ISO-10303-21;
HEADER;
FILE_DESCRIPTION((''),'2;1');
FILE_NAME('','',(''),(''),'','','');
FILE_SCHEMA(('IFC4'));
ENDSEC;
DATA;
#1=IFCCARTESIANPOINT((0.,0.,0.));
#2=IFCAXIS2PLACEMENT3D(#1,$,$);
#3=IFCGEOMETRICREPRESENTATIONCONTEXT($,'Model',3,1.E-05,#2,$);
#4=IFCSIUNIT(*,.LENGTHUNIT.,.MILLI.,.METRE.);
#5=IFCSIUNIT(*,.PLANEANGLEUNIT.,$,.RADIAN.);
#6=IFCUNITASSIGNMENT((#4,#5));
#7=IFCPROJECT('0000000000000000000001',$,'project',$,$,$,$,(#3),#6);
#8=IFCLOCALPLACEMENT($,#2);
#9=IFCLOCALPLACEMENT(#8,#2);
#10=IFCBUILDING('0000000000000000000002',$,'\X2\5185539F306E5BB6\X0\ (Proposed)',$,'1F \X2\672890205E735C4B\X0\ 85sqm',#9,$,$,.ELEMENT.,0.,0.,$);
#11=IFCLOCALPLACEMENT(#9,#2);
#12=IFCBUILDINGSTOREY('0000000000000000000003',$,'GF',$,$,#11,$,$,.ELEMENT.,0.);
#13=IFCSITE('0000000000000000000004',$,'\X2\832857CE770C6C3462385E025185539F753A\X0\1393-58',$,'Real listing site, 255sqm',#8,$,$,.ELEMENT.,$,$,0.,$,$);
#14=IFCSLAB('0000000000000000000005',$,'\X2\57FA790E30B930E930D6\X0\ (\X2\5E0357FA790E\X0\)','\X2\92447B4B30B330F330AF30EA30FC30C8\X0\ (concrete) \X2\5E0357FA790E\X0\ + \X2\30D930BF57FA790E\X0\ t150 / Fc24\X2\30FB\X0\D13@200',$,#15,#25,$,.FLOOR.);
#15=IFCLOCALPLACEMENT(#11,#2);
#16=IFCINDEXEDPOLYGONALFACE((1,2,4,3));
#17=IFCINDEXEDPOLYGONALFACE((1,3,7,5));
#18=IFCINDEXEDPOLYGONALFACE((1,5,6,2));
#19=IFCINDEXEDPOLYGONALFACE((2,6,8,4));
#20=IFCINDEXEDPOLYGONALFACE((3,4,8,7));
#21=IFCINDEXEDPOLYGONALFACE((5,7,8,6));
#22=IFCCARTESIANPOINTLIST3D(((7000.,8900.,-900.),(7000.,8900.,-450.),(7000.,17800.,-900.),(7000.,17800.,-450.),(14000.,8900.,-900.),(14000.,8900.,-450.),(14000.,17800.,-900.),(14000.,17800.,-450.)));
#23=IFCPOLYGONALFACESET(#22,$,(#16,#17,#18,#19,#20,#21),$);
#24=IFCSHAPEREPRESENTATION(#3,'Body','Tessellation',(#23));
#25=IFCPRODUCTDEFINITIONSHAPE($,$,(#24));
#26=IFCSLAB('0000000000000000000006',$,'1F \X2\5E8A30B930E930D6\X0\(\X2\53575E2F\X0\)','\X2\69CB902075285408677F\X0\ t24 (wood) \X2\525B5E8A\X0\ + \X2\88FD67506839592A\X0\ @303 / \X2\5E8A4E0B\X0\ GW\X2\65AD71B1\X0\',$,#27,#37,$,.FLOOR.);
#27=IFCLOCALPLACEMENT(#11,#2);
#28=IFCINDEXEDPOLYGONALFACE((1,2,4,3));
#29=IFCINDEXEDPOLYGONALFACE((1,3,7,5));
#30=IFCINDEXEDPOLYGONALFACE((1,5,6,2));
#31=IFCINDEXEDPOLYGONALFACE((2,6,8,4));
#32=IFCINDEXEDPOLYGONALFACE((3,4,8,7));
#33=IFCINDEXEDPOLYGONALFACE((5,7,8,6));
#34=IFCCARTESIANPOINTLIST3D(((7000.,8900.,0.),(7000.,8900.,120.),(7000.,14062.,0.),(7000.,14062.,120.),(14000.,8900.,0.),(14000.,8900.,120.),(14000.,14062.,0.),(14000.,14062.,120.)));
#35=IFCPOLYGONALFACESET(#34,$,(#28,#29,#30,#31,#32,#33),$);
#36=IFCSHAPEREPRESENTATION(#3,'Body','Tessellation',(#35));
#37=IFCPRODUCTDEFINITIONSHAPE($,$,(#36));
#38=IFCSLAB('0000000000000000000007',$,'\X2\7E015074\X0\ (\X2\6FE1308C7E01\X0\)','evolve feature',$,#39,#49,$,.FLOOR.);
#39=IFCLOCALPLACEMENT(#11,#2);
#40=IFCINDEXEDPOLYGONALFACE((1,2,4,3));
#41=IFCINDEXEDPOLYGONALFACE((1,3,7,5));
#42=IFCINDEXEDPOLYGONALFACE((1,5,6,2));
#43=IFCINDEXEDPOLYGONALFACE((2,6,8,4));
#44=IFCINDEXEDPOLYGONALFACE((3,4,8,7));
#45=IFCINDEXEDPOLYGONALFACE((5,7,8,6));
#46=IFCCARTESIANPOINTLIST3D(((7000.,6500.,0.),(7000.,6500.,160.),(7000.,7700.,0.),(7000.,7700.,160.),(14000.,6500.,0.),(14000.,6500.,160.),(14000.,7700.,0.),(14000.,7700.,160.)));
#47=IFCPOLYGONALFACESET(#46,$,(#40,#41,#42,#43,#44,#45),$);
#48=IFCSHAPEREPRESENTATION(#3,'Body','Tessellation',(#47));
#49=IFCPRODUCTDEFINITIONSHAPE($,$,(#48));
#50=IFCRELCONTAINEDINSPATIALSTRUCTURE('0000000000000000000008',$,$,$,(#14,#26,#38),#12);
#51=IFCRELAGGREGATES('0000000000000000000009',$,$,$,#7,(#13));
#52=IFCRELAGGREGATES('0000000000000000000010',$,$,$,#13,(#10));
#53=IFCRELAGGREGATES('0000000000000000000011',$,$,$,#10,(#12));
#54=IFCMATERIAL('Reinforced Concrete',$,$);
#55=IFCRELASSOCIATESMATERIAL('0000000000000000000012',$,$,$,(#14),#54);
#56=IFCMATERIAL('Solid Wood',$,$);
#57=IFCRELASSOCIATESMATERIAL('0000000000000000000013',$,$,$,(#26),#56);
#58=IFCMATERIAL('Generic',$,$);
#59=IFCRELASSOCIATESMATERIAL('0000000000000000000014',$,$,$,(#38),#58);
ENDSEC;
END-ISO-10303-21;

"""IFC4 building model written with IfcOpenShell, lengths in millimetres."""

from ifc_helpers import new_model, si_unit, frame, frame_2d, origin, place, context, project, spatial, rectangle, extrude, material, element, save


model = new_model("IFC4")

# Units and contexts
model_context = context("Model", 3, precision=1e-05, world=origin())
ifc_project = project(units=[si_unit("LENGTHUNIT", "METRE", prefix="MILLI"), si_unit("PLANEANGLEUNIT", "RADIAN")], contexts=[model_context])

# Site, building, storey
site_placement = place(None, origin())
site = spatial("IfcSite", under=ifc_project, at=site_placement, Name="茨城県水戸市内原町1393-58", ObjectType="Real listing site, 255sqm", CompositionType="ELEMENT", RefElevation=0.0)
building_placement = place(site_placement, origin())
building = spatial("IfcBuilding", under=site, at=building_placement, Name="内原の家 (Proposed)", ObjectType="1F 木造平屋 85sqm", CompositionType="ELEMENT", ElevationOfRefHeight=0.0, ElevationOfTerrain=0.0)
storey_placement = place(building_placement, origin())
storey = spatial("IfcBuildingStorey", under=building, at=storey_placement, Name="GF", CompositionType="ELEMENT", Elevation=0.0)

# Slabs
ifc_material_1 = material(Name="Reinforced Concrete")
slab_1_placement = place(storey_placement, frame((3500.0, 4450.0, -450.0)))
element("IfcSlab", 1, at=slab_1_placement, inside=storey, material=ifc_material_1, Name="基礎スラブ (布基礎)", Description="鉄筋コンクリート (concrete) 布基礎 + ベタ基礎 t150 / Fc24・D13@200", PredefinedType="FLOOR", context=model_context, shape_type="SweptSolid", body=[
    extrude(rectangle(XDim=7000.0, YDim=8900.0, at=frame_2d((3500.0, 4450.0))), frame((3500.0, 4450.0, -450.0)), (0.0, 0.0, 1.0), 450.0),
])
ifc_material_2 = material(Name="Solid Wood")
slab_2_placement = place(storey_placement, frame((3500.0, 4450.0, 0.0)))
element("IfcSlab", 2, at=slab_2_placement, inside=storey, material=ifc_material_2, Name="1F 床スラブ(南帯)", Description="構造用合板 t24 (wood) 剛床 + 製材根太 @303 / 床下 GW断熱", PredefinedType="FLOOR", context=model_context, shape_type="SweptSolid", body=[
    extrude(rectangle(XDim=7000.0, YDim=5162.0, at=frame_2d((3500.0, 2581.0))), frame((3500.0, 4450.0, 0.0)), (0.0, 0.0, 1.0), 120.0),
])
ifc_material_3 = material(Name="Generic")
slab_3_placement = place(storey_placement, frame((3500.0, 3250.0, 0.0)))
element("IfcSlab", 3, at=slab_3_placement, inside=storey, material=ifc_material_3, Name="縁側 (濡れ縁)", Description="evolve feature", PredefinedType="FLOOR", context=model_context, shape_type="SweptSolid", body=[
    extrude(rectangle(XDim=7000.0, YDim=1200.0, at=frame_2d((3500.0, 600.0))), frame((3500.0, 3250.0, 0.0)), (0.0, 0.0, 1.0), 160.0),
])

save(model, "model.ifc")
